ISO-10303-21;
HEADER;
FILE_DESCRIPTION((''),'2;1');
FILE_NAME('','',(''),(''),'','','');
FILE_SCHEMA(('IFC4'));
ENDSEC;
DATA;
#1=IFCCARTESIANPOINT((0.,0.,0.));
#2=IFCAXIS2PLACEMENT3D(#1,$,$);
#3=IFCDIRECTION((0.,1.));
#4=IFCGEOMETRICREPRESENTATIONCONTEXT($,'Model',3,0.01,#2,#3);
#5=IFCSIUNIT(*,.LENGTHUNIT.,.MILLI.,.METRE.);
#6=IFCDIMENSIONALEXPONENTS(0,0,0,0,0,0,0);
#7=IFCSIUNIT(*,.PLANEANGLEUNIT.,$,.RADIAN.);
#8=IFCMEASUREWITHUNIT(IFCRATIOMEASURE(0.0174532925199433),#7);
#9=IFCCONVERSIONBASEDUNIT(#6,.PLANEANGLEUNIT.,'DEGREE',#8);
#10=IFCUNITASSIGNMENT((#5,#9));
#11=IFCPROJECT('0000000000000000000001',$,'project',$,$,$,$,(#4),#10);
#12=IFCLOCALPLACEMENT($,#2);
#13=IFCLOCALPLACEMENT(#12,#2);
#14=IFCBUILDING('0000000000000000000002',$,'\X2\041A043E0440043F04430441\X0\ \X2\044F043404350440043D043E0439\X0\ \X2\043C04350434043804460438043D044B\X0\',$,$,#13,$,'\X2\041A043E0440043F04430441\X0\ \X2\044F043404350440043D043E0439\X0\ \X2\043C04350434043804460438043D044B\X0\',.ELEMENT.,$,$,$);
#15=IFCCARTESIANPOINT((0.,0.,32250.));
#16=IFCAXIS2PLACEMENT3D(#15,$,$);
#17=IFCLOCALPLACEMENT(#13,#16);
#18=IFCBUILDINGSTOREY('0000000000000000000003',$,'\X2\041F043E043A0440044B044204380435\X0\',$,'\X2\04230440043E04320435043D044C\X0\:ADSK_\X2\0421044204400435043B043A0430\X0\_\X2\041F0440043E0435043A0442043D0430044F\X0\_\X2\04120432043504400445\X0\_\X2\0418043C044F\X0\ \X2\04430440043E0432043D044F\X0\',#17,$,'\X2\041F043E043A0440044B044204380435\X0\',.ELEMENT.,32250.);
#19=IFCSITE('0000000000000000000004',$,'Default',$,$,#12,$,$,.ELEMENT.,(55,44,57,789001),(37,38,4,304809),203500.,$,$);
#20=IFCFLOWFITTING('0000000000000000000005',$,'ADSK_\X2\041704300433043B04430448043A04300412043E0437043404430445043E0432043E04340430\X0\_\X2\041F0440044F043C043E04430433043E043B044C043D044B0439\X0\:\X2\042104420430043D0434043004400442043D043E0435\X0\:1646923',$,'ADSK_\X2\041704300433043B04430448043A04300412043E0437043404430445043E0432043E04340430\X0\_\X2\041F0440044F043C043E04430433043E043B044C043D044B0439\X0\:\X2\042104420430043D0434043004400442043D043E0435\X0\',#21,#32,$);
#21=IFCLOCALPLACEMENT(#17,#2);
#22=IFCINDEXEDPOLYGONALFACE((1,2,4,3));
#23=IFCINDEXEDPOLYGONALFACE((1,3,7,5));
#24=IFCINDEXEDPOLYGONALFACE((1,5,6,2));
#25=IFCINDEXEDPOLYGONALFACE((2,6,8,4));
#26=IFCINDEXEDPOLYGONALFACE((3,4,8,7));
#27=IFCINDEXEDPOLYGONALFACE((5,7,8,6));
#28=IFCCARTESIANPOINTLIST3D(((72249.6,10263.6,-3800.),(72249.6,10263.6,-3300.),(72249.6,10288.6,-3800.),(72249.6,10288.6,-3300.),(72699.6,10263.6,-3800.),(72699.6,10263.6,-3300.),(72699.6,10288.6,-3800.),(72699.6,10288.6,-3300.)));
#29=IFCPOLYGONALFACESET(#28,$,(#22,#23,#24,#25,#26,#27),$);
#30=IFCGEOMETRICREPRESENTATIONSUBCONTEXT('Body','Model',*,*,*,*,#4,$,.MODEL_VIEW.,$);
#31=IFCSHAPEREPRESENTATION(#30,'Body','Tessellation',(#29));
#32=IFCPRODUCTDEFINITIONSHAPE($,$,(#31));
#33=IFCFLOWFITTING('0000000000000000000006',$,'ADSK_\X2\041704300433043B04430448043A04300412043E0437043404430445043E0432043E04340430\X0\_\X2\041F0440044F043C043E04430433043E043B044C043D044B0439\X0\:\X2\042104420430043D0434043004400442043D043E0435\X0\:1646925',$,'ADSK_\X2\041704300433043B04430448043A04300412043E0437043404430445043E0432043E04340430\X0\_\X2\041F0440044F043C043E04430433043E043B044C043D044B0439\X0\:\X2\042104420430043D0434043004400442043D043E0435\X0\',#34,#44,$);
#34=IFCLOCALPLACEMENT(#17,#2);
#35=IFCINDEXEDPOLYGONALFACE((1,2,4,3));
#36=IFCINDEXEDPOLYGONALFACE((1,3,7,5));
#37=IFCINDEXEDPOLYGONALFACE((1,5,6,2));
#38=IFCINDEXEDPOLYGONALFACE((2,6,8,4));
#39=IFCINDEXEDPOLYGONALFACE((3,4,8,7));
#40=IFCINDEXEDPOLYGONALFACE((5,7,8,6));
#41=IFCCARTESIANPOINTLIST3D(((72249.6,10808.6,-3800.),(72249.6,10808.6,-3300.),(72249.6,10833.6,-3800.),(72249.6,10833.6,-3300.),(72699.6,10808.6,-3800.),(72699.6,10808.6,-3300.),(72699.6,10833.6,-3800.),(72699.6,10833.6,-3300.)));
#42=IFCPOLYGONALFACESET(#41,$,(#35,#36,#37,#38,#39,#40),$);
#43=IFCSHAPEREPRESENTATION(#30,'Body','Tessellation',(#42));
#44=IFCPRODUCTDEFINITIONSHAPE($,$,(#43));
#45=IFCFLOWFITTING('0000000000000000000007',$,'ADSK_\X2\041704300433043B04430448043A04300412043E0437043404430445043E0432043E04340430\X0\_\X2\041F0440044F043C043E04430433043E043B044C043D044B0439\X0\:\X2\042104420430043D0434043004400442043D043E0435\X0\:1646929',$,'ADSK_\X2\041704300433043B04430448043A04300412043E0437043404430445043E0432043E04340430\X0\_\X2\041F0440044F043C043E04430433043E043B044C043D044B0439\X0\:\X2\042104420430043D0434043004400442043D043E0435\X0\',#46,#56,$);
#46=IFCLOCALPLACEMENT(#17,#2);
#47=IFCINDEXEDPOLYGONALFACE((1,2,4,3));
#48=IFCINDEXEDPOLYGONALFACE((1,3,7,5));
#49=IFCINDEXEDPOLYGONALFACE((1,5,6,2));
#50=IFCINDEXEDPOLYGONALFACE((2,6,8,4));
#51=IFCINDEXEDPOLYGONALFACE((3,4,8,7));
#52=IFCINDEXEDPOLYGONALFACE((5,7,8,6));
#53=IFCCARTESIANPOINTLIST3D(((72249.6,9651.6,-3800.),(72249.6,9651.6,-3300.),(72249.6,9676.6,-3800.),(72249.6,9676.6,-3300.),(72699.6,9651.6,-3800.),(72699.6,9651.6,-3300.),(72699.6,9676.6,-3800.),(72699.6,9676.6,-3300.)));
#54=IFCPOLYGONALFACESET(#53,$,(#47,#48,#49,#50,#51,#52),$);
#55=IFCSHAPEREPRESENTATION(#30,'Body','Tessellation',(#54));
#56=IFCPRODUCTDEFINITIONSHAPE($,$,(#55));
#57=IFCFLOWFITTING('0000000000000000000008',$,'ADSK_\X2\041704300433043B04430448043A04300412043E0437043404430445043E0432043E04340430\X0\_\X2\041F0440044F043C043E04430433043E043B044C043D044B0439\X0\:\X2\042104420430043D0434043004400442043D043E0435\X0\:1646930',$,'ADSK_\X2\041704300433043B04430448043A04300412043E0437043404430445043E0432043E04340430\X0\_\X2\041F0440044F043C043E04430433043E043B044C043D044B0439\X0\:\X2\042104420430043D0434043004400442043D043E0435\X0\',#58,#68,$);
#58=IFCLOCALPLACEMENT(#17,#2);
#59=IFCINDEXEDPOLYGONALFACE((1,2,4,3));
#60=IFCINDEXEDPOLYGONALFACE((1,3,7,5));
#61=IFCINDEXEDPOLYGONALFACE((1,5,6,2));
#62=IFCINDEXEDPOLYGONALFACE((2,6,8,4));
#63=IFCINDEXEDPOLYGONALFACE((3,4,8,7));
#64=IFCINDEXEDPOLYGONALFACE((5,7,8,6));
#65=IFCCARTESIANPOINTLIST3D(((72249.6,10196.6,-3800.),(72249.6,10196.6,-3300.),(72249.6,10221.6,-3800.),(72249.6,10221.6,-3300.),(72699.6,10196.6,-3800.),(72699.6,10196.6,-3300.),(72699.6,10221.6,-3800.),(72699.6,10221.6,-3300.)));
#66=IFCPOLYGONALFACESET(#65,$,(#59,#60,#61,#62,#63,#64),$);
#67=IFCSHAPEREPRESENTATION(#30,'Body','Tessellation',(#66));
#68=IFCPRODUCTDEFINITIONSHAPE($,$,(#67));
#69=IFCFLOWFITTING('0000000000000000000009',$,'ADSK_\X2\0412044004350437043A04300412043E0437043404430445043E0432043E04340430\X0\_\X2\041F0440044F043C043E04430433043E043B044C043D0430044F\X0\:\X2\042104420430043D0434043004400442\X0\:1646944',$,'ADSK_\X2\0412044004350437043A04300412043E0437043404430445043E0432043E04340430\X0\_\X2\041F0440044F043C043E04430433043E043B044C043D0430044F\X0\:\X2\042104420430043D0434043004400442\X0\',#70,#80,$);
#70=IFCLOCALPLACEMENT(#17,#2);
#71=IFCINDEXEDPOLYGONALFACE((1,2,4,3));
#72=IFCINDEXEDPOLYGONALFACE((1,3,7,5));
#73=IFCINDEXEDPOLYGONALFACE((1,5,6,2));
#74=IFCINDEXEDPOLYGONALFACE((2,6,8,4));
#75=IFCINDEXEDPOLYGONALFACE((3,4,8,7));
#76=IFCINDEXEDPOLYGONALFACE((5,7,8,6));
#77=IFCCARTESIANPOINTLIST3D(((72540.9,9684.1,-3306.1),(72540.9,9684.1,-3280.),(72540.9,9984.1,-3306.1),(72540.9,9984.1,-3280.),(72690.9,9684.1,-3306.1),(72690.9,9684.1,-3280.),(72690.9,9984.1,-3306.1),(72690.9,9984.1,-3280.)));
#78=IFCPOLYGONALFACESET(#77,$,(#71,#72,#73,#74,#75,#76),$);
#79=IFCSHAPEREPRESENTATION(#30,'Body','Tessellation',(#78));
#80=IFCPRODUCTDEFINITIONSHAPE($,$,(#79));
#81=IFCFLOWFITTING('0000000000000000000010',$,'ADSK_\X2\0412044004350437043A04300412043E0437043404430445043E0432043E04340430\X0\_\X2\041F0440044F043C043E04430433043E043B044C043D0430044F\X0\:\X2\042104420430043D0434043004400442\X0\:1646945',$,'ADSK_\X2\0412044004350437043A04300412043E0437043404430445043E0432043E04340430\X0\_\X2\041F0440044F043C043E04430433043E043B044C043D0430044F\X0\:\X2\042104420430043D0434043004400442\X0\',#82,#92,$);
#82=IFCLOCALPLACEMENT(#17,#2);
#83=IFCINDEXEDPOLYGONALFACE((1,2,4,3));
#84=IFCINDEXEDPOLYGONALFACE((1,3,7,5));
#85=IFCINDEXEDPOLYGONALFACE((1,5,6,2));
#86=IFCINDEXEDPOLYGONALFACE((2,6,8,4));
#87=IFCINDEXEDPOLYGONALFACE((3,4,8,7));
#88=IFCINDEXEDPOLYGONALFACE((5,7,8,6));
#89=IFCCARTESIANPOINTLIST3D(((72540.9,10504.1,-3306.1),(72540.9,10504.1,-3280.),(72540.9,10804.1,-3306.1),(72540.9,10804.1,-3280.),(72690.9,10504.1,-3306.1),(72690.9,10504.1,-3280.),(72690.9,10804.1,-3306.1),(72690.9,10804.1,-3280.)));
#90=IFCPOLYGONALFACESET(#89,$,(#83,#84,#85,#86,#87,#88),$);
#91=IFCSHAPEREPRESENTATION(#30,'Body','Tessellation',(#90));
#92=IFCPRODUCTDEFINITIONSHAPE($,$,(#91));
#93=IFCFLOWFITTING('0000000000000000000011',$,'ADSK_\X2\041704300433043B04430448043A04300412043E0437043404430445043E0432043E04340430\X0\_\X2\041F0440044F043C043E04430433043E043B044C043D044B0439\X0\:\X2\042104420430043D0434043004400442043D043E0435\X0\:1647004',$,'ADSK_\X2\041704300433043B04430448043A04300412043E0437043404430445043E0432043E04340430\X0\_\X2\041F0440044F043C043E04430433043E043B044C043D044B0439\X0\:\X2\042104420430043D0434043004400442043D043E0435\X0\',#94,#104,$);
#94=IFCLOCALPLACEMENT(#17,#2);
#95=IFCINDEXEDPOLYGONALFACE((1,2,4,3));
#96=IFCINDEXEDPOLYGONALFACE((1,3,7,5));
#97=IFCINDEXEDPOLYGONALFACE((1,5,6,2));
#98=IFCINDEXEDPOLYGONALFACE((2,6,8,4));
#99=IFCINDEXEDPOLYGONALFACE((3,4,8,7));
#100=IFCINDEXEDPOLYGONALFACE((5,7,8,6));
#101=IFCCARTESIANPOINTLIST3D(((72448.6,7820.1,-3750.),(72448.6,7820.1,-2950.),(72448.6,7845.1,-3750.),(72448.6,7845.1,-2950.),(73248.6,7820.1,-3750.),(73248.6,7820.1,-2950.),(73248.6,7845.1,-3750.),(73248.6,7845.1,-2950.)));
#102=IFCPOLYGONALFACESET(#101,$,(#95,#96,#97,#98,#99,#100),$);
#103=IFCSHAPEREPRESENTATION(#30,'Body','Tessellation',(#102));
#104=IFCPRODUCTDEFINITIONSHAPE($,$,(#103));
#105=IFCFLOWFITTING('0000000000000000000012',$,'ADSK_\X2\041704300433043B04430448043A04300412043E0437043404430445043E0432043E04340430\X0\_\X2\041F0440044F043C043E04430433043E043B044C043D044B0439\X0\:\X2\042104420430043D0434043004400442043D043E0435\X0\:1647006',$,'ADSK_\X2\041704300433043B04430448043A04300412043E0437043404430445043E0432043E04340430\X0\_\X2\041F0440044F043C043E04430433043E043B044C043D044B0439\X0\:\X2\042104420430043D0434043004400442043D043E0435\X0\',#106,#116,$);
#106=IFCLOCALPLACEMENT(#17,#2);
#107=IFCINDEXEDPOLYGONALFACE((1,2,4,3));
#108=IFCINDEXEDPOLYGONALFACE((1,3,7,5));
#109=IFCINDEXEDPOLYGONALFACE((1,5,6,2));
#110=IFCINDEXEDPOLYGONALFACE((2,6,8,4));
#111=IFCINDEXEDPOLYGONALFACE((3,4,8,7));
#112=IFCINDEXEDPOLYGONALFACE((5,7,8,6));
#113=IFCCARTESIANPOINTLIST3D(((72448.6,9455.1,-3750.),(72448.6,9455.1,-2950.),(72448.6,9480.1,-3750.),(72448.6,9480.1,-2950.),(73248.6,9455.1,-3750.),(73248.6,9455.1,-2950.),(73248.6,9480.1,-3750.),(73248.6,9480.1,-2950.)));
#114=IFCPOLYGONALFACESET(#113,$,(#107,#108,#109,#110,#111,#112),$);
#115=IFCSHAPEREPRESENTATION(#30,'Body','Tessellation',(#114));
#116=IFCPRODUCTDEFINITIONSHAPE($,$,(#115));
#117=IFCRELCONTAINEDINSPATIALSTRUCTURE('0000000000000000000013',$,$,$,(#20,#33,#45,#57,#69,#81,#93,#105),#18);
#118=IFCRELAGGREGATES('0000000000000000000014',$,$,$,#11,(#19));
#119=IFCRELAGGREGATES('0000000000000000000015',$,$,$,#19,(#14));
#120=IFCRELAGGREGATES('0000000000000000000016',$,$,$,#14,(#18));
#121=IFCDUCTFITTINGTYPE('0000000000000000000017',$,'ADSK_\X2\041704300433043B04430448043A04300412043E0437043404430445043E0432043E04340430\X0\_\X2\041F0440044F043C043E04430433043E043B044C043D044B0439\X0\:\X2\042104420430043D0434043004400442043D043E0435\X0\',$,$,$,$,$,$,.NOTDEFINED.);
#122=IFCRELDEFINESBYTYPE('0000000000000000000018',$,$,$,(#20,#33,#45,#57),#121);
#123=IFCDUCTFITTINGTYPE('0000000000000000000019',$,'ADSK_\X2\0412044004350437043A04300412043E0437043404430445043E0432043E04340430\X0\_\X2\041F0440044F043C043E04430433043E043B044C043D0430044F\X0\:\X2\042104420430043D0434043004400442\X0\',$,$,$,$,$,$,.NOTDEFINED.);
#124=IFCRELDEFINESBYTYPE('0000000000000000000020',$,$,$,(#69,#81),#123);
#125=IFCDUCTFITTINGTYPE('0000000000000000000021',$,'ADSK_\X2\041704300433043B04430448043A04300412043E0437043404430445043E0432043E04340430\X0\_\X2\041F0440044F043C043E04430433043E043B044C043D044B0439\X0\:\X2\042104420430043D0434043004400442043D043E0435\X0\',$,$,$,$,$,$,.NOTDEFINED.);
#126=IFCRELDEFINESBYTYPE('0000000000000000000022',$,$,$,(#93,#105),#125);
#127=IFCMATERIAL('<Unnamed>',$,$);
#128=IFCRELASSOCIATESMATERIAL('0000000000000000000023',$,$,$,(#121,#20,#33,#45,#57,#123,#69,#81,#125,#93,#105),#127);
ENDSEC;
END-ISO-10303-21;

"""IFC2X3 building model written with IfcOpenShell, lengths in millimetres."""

from ifc_helpers import new_model, entity, si_unit, converted_unit, direction, frame, origin, origin_2d_with_axis, place, context, subcontext, project, spatial, rectangle, extrude, source, transform, mapped, material, type_object, type_shapes, element, save


model = new_model("IFC2X3")

# Units and contexts
model_context = context("Model", 3, precision=0.01, world=origin(), true_north=direction((0.0, 1.0)))
body_context = subcontext(model_context, "Body", "Model", "MODEL_VIEW")
ifc_project = project(units=[si_unit("LENGTHUNIT", "METRE", prefix="MILLI"), converted_unit("PLANEANGLEUNIT", "DEGREE", entity("IfcRatioMeasure", 0.0174532925199433), si_unit("PLANEANGLEUNIT", "RADIAN"), dimensions=[0, 0, 0, 0, 0, 0, 0])], contexts=[model_context])

# Site, building, storey
site_placement = place(None, origin())
site = spatial("IfcSite", under=ifc_project, at=site_placement, Name="Default", CompositionType="ELEMENT", RefLatitude=(55, 44, 57, 789001), RefLongitude=(37, 38, 4, 304809), RefElevation=203500.0)
building_placement = place(site_placement, origin())
building = spatial("IfcBuilding", under=site, at=building_placement, Name="Корпус ядерной медицины", LongName="Корпус ядерной медицины", CompositionType="ELEMENT")
storey_placement = place(building_placement, frame((0.0, 0.0, 32250.0)))
storey = spatial("IfcBuildingStorey", under=building, at=storey_placement, Name="Покрытие", ObjectType="Уровень:ADSK_Стрелка_Проектная_Вверх_Имя уровня", LongName="Покрытие", CompositionType="ELEMENT", Elevation=32250.0)

# Flow fittings
ifc_material = material(Name="<Unnamed>")
duct_fitting_type_1 = type_object("IfcDuctFittingType", Name="ADSK_ЗаглушкаВоздуховода_Прямоугольный:Стандартное", PredefinedType="NOTDEFINED", material=ifc_material)
shared_shape_1 = source(origin(), body_context, "Body", "SweptSolid", [
    extrude(rectangle(XDim=25.0, YDim=450.0, at=origin_2d_with_axis()), frame((12.5, 0.0, -250.0)), (0.0, 0.0, 1.0), 500.0),
])
type_shapes(duct_fitting_type_1, [shared_shape_1])
for number, where, z_axis, x_axis, name in (
    (1, (72474.6, 10288.6, -3550.0), (0.0, 0.0, 1.0), (0.0, -1.0, 0.0), "ADSK_ЗаглушкаВоздуховода_Прямоугольный:Стандартное:1646923"),
    (2, (72474.6, 10808.6, -3550.0), (0.0, 0.0, 1.0), (0.0, 1.0, 0.0), "ADSK_ЗаглушкаВоздуховода_Прямоугольный:Стандартное:1646925"),
    (3, (72474.6, 9676.6, -3550.0), (0.0, 0.0, 1.0), (0.0, -1.0, 0.0), "ADSK_ЗаглушкаВоздуховода_Прямоугольный:Стандартное:1646929"),
    (4, (72474.6, 10196.6, -3550.0), (0.0, 0.0, 1.0), (0.0, 1.0, 0.0), "ADSK_ЗаглушкаВоздуховода_Прямоугольный:Стандартное:1646930"),
):
    element("IfcFlowFitting", number, at=place(storey_placement, frame(where, z_axis=z_axis, x_axis=x_axis)), inside=storey, type_object=duct_fitting_type_1, material=ifc_material, Name=name, ObjectType="ADSK_ЗаглушкаВоздуховода_Прямоугольный:Стандартное", context=body_context, shape_type="MappedRepresentation", body=[
        mapped(shared_shape_1, transform((0.0, 0.0, 0.0), scale=1.0)),
    ])
duct_fitting_type_2 = type_object("IfcDuctFittingType", Name="ADSK_ВрезкаВоздуховода_Прямоугольная:Стандарт", PredefinedType="NOTDEFINED", material=ifc_material)
shared_shape_2 = source(origin(), body_context, "Body", "SweptSolid", [
    extrude(rectangle(XDim=150.0, YDim=26.1, at=origin_2d_with_axis()), frame((7.0, 0.0, -150.0), z_axis=(0.0, 0.0, 1.0), x_axis=(0.0, -1.0, 0.0)), (0.0, 0.0, 1.0), 300.0),
])
type_shapes(duct_fitting_type_2, [shared_shape_2])
for number, where, z_axis, x_axis, name in (
    (5, (72615.9, 9834.1, -3300.0), (0.0, 1.0, 0.0), (0.0, 0.0, 1.0), "ADSK_ВрезкаВоздуховода_Прямоугольная:Стандарт:1646944"),
    (6, (72615.9, 10654.1, -3300.0), (0.0, 1.0, 0.0), (0.0, 0.0, 1.0), "ADSK_ВрезкаВоздуховода_Прямоугольная:Стандарт:1646945"),
):
    element("IfcFlowFitting", number, at=place(storey_placement, frame(where, z_axis=z_axis, x_axis=x_axis)), inside=storey, type_object=duct_fitting_type_2, material=ifc_material, Name=name, ObjectType="ADSK_ВрезкаВоздуховода_Прямоугольная:Стандарт", context=body_context, shape_type="MappedRepresentation", body=[
        mapped(shared_shape_2, transform((0.0, 0.0, 0.0), scale=1.0)),
    ])
duct_fitting_type_3 = type_object("IfcDuctFittingType", Name="ADSK_ЗаглушкаВоздуховода_Прямоугольный:Стандартное", PredefinedType="NOTDEFINED", material=ifc_material)
shared_shape_3 = source(origin(), body_context, "Body", "SweptSolid", [
    extrude(rectangle(XDim=25.0, YDim=800.0, at=origin_2d_with_axis()), frame((12.5, 0.0, -400.0)), (0.0, 0.0, 1.0), 800.0),
])
type_shapes(duct_fitting_type_3, [shared_shape_3])
for number, where, z_axis, x_axis, name in (
    (7, (72848.6, 7845.1, -3350.0), (0.0, 0.0, 1.0), (0.0, -1.0, 0.0), "ADSK_ЗаглушкаВоздуховода_Прямоугольный:Стандартное:1647004"),
    (8, (72848.6, 9455.1, -3350.0), (0.0, 0.0, 1.0), (0.0, 1.0, 0.0), "ADSK_ЗаглушкаВоздуховода_Прямоугольный:Стандартное:1647006"),
):
    element("IfcFlowFitting", number, at=place(storey_placement, frame(where, z_axis=z_axis, x_axis=x_axis)), inside=storey, type_object=duct_fitting_type_3, material=ifc_material, Name=name, ObjectType="ADSK_ЗаглушкаВоздуховода_Прямоугольный:Стандартное", context=body_context, shape_type="MappedRepresentation", body=[
        mapped(shared_shape_3, transform((0.0, 0.0, 0.0), scale=1.0)),
    ])

save(model, "model.ifc")
